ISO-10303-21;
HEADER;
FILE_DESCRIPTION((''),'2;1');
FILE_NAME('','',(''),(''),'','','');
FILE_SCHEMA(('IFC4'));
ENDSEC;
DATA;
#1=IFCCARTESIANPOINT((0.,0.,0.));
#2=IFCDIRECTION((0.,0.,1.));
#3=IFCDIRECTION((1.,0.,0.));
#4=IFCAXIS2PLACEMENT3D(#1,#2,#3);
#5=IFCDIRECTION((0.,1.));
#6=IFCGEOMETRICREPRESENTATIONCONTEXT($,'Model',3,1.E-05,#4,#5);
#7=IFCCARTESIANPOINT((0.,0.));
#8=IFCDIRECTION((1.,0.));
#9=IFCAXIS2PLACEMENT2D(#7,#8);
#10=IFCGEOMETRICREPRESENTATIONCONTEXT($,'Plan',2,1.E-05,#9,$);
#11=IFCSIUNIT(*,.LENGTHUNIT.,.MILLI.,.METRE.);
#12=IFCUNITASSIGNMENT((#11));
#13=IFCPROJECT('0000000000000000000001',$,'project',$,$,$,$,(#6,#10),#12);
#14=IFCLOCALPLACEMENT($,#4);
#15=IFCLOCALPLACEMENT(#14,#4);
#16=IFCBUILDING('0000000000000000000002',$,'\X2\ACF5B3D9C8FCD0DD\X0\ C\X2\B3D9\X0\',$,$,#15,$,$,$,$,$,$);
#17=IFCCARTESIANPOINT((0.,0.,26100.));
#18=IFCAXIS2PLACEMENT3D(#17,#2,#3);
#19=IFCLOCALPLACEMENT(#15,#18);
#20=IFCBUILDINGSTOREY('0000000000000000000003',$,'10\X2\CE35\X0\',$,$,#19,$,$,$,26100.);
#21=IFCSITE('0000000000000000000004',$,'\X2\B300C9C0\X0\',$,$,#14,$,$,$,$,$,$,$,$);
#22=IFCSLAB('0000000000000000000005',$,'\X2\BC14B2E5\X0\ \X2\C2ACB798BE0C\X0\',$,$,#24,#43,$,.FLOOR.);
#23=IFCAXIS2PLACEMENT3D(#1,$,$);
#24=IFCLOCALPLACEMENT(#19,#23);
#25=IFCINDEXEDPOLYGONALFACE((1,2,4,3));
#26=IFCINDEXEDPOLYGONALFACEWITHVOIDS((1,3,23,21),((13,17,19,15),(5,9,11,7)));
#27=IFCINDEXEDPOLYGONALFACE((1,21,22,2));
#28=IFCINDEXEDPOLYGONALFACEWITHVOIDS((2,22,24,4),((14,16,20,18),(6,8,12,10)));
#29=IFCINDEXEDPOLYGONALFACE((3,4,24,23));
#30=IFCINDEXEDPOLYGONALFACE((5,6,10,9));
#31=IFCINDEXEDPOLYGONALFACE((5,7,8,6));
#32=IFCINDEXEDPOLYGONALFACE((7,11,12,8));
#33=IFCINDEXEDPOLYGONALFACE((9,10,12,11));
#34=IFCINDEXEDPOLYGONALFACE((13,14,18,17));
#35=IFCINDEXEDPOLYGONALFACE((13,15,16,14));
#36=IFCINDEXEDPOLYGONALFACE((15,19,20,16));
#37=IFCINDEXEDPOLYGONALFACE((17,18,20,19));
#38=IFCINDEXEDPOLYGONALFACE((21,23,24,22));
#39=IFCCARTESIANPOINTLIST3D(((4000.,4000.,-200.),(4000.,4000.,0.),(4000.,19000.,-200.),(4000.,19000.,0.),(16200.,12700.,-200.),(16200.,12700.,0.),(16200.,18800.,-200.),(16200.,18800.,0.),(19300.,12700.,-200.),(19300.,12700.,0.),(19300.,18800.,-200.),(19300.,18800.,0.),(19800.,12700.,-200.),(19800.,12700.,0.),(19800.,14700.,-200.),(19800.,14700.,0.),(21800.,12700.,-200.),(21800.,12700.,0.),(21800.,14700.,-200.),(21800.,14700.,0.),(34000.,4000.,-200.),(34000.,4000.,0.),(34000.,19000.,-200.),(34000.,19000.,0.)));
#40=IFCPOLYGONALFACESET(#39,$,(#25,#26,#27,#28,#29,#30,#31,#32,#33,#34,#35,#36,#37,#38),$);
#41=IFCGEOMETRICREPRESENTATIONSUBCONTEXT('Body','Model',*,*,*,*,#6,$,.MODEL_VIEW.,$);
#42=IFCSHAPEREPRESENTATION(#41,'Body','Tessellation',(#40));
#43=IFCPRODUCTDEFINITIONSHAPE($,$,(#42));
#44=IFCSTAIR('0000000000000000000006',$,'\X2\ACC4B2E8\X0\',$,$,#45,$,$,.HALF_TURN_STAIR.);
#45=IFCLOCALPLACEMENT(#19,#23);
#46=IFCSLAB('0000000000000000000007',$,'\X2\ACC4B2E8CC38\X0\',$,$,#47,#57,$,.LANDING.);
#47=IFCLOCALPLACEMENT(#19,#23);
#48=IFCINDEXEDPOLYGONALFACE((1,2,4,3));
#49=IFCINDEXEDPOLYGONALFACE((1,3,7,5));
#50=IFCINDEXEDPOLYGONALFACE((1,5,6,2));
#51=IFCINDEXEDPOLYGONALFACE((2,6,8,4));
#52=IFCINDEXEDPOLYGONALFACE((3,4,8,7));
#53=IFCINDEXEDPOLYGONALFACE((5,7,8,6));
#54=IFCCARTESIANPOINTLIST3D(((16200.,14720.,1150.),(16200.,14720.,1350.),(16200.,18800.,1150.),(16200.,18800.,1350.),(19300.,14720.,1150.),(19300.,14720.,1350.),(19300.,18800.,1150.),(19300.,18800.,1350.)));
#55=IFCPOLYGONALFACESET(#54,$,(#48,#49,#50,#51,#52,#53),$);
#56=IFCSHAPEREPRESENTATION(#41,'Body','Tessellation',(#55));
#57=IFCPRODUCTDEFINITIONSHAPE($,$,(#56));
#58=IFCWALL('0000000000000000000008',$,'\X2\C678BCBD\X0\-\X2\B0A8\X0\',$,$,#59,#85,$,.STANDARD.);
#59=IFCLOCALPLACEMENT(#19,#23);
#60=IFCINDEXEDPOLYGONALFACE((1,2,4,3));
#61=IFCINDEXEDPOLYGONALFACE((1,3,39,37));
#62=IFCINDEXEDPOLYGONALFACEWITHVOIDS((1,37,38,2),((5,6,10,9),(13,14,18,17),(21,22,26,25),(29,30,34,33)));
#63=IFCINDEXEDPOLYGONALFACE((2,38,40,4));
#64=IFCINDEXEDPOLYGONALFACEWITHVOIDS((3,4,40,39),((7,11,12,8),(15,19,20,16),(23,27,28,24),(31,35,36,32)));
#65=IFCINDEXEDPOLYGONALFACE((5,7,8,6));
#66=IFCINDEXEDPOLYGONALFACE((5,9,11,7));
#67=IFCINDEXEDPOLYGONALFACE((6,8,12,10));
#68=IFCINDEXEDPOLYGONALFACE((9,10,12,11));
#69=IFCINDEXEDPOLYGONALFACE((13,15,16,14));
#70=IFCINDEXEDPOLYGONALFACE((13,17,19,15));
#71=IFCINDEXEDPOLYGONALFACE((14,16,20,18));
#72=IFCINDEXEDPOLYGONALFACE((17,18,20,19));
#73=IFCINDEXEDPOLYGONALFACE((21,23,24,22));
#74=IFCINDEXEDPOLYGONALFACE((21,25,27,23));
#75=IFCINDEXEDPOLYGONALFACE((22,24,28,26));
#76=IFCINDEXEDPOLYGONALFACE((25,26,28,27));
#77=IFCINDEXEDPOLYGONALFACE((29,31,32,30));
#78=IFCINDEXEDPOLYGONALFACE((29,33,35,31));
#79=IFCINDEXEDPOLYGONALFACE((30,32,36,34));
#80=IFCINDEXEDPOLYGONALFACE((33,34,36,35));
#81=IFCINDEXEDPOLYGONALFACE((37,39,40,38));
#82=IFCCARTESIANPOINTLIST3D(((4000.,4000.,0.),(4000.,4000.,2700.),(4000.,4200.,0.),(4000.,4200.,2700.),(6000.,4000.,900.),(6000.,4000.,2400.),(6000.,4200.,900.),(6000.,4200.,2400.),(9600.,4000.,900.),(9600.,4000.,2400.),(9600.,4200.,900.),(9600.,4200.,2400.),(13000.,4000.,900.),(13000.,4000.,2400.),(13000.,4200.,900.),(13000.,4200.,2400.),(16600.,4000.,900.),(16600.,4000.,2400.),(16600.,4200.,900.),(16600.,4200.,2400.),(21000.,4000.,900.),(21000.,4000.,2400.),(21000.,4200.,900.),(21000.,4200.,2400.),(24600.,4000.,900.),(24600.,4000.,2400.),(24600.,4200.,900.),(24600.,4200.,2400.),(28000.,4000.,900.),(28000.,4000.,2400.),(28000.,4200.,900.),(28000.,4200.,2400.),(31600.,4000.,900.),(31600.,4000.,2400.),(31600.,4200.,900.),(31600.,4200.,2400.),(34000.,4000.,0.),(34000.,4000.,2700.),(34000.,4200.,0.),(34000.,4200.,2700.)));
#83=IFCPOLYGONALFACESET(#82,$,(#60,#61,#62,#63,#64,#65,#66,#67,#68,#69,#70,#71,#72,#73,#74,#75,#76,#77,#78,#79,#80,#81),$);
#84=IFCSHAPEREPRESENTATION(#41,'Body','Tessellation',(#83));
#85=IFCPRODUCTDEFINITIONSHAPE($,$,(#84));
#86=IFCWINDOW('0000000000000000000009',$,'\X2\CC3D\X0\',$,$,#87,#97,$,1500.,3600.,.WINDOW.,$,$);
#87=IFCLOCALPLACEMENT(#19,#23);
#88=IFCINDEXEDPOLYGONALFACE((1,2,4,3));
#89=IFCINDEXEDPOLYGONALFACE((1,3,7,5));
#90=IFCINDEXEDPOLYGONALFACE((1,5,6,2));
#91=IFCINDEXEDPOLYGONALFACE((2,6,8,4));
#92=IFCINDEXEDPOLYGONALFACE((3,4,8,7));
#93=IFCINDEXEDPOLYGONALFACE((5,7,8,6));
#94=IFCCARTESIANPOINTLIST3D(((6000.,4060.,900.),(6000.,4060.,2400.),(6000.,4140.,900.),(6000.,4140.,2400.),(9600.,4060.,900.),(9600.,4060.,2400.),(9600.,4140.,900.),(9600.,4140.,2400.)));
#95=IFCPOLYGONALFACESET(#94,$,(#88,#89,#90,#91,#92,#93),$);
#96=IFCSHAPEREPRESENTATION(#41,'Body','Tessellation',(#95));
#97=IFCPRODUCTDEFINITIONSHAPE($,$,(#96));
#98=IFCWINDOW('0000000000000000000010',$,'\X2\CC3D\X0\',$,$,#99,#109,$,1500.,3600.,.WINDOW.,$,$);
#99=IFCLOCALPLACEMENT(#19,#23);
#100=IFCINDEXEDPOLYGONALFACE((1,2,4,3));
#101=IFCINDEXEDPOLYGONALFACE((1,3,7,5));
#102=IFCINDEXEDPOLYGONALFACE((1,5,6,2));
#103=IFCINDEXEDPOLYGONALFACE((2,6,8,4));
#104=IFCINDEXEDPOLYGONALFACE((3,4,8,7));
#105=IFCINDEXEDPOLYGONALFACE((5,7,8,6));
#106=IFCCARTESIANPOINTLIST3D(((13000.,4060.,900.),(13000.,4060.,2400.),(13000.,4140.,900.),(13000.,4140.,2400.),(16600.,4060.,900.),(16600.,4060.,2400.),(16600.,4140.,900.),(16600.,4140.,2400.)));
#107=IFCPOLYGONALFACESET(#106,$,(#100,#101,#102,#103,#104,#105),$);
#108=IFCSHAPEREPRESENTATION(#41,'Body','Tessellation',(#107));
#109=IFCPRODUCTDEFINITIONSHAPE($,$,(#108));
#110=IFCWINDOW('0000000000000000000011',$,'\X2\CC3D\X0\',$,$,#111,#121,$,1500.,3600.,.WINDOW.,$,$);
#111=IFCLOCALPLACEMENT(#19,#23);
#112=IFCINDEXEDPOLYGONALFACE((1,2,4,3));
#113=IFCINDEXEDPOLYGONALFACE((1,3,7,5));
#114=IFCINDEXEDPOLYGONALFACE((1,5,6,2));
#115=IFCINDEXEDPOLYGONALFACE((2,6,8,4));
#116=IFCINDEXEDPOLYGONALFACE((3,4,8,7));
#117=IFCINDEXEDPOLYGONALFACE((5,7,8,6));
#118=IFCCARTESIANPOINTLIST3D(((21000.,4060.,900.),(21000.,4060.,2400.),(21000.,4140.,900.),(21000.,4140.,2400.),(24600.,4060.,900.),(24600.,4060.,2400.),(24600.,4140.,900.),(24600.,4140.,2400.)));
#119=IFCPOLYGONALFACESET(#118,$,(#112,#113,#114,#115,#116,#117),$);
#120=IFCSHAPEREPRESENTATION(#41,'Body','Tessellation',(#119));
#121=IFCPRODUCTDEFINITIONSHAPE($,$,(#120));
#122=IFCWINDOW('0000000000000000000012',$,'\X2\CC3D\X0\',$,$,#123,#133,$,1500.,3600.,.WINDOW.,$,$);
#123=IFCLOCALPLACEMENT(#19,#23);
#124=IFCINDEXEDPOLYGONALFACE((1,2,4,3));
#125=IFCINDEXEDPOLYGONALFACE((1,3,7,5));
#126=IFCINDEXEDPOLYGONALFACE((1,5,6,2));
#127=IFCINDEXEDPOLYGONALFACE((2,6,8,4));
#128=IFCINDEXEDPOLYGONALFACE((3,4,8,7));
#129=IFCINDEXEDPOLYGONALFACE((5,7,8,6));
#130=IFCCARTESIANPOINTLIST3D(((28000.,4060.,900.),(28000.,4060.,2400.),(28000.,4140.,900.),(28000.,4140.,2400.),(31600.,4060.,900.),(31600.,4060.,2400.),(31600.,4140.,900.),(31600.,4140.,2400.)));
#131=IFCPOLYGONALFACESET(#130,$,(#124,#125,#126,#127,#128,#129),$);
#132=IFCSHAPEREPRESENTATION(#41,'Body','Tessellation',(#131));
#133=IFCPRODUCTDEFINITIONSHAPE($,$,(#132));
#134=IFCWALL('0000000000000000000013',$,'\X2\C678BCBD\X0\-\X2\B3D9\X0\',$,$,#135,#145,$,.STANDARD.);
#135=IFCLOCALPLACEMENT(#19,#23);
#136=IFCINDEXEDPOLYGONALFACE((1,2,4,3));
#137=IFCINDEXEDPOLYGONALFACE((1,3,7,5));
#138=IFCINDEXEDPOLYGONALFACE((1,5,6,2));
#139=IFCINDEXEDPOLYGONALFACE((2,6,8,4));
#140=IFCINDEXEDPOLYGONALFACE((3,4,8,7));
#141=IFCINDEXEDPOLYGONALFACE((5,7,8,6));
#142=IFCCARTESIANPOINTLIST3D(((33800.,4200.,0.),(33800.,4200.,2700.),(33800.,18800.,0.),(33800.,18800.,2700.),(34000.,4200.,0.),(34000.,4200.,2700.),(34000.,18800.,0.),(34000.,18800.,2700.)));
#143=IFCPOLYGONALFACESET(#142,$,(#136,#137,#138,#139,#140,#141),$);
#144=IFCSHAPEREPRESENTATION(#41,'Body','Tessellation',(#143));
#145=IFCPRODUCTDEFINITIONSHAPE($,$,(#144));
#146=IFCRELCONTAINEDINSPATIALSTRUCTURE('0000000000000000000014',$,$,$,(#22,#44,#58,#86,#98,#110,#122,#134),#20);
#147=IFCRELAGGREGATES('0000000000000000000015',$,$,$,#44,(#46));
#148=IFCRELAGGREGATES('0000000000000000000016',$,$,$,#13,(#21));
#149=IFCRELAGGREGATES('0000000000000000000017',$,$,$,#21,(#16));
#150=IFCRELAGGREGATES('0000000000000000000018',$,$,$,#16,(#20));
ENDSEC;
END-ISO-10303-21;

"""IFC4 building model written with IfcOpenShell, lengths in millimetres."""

from ifc_helpers import new_model, si_unit, direction, frame, origin_with_axes, origin_2d_with_axis, place, context, subcontext, project, spatial, polyline, outline, extrude, element, fill, aggregate, save


model = new_model("IFC4")

# Units and contexts
model_context = context("Model", 3, precision=1e-05, world=origin_with_axes(), true_north=direction((0.0, 1.0)))
plan_context = context("Plan", 2, precision=1e-05, world=origin_2d_with_axis())
body_context = subcontext(model_context, "Body", "Model", "MODEL_VIEW")
ifc_project = project(units=[si_unit("LENGTHUNIT", "METRE", prefix="MILLI")], contexts=[model_context, plan_context])

# Site, building, storey
site_placement = place(None, origin_with_axes())
site = spatial("IfcSite", under=ifc_project, at=site_placement, Name="대지")
building_placement = place(site_placement, origin_with_axes())
building = spatial("IfcBuilding", under=site, at=building_placement, Name="공동주택 C동")
storey_placement = place(building_placement, frame((0.0, 0.0, 26100.0), z_axis=(0.0, 0.0, 1.0), x_axis=(1.0, 0.0, 0.0)))
storey = spatial("IfcBuildingStorey", under=building, at=storey_placement, Name="10층", Elevation=26100.0)

# Slab
slab_1_placement = place(storey_placement, origin_with_axes())
element("IfcSlab", 1, at=slab_1_placement, inside=storey, Name="바닥 슬래브", PredefinedType="FLOOR", context=body_context, shape_type="SweptSolid", body=[
    extrude(outline(polyline([(4000.0, 4000.0), (34000.0, 4000.0), (34000.0, 19000.0), (4000.0, 19000.0), (4000.0, 4000.0)]), holes=[polyline([(16200.0, 12700.0), (19300.0, 12700.0), (19300.0, 18800.0), (16200.0, 18800.0), (16200.0, 12700.0)]), polyline([(19800.0, 12700.0), (21800.0, 12700.0), (21800.0, 14700.0), (19800.0, 14700.0), (19800.0, 12700.0)])]), frame((0.0, 0.0, -200.0), z_axis=(0.0, 0.0, 1.0), x_axis=(1.0, 0.0, 0.0)), (0.0, 0.0, 1.0), 200.0),
])

# Stair, slab
stair_placement = place(storey_placement, origin_with_axes())
stair = element("IfcStair", 2, at=stair_placement, inside=storey, Name="계단", PredefinedType="HALF_TURN_STAIR")
slab_2_placement = place(stair_placement, origin_with_axes())
slab_2 = element("IfcSlab", 3, at=slab_2_placement, Name="계단참", PredefinedType="LANDING", context=body_context, shape_type="SweptSolid", body=[
    extrude(outline(polyline([(16200.0, 14720.0), (19300.0, 14720.0), (19300.0, 18800.0), (16200.0, 18800.0), (16200.0, 14720.0)])), frame((0.0, 0.0, 1150.0), z_axis=(0.0, 0.0, 1.0), x_axis=(1.0, 0.0, 0.0)), (0.0, 0.0, 1.0), 200.0),
])

# Wall, openings, windows
wall_1_placement = place(storey_placement, origin_with_axes())
wall_1 = element("IfcWall", 4, at=wall_1_placement, inside=storey, Name="외벽-남", PredefinedType="STANDARD", context=body_context, shape_type="SweptSolid", body=[
    extrude(outline(polyline([(4000.0, 4200.0), (34000.0, 4200.0), (34000.0, 4000.0), (4000.0, 4000.0), (4000.0, 4200.0)])), origin_with_axes(), (0.0, 0.0, 1.0), 2700.0),
])
opening_1_placement = place(storey_placement, origin_with_axes())
opening_1 = element("IfcOpeningElement", 5, at=opening_1_placement, cuts=wall_1, PredefinedType="OPENING", context=body_context, shape_type="SweptSolid", body=[
    extrude(outline(polyline([(6000.0, 3950.0), (9600.0, 3950.0), (9600.0, 4250.0), (6000.0, 4250.0), (6000.0, 3950.0)])), frame((0.0, 0.0, 900.0), z_axis=(0.0, 0.0, 1.0), x_axis=(1.0, 0.0, 0.0)), (0.0, 0.0, 1.0), 1500.0),
])
opening_2_placement = place(storey_placement, origin_with_axes())
opening_2 = element("IfcOpeningElement", 6, at=opening_2_placement, cuts=wall_1, PredefinedType="OPENING", context=body_context, shape_type="SweptSolid", body=[
    extrude(outline(polyline([(13000.0, 3950.0), (16600.0, 3950.0), (16600.0, 4250.0), (13000.0, 4250.0), (13000.0, 3950.0)])), frame((0.0, 0.0, 900.0), z_axis=(0.0, 0.0, 1.0), x_axis=(1.0, 0.0, 0.0)), (0.0, 0.0, 1.0), 1500.0),
])
opening_3_placement = place(storey_placement, origin_with_axes())
opening_3 = element("IfcOpeningElement", 7, at=opening_3_placement, cuts=wall_1, PredefinedType="OPENING", context=body_context, shape_type="SweptSolid", body=[
    extrude(outline(polyline([(21000.0, 3950.0), (24600.0, 3950.0), (24600.0, 4250.0), (21000.0, 4250.0), (21000.0, 3950.0)])), frame((0.0, 0.0, 900.0), z_axis=(0.0, 0.0, 1.0), x_axis=(1.0, 0.0, 0.0)), (0.0, 0.0, 1.0), 1500.0),
])
opening_4_placement = place(storey_placement, origin_with_axes())
opening_4 = element("IfcOpeningElement", 8, at=opening_4_placement, cuts=wall_1, PredefinedType="OPENING", context=body_context, shape_type="SweptSolid", body=[
    extrude(outline(polyline([(28000.0, 3950.0), (31600.0, 3950.0), (31600.0, 4250.0), (28000.0, 4250.0), (28000.0, 3950.0)])), frame((0.0, 0.0, 900.0), z_axis=(0.0, 0.0, 1.0), x_axis=(1.0, 0.0, 0.0)), (0.0, 0.0, 1.0), 1500.0),
])
window_1_placement = place(storey_placement, origin_with_axes())
window_1 = element("IfcWindow", 9, at=window_1_placement, inside=storey, Name="창", OverallHeight=1500.0, OverallWidth=3600.0, PredefinedType="WINDOW", context=body_context, shape_type="SweptSolid", body=[
    extrude(outline(polyline([(6000.0, 4060.0), (9600.0, 4060.0), (9600.0, 4140.0), (6000.0, 4140.0), (6000.0, 4060.0)])), frame((0.0, 0.0, 900.0), z_axis=(0.0, 0.0, 1.0), x_axis=(1.0, 0.0, 0.0)), (0.0, 0.0, 1.0), 1500.0),
])
fill(opening_1, window_1)
window_2_placement = place(storey_placement, origin_with_axes())
window_2 = element("IfcWindow", 10, at=window_2_placement, inside=storey, Name="창", OverallHeight=1500.0, OverallWidth=3600.0, PredefinedType="WINDOW", context=body_context, shape_type="SweptSolid", body=[
    extrude(outline(polyline([(13000.0, 4060.0), (16600.0, 4060.0), (16600.0, 4140.0), (13000.0, 4140.0), (13000.0, 4060.0)])), frame((0.0, 0.0, 900.0), z_axis=(0.0, 0.0, 1.0), x_axis=(1.0, 0.0, 0.0)), (0.0, 0.0, 1.0), 1500.0),
])
fill(opening_2, window_2)
window_3_placement = place(storey_placement, origin_with_axes())
window_3 = element("IfcWindow", 11, at=window_3_placement, inside=storey, Name="창", OverallHeight=1500.0, OverallWidth=3600.0, PredefinedType="WINDOW", context=body_context, shape_type="SweptSolid", body=[
    extrude(outline(polyline([(21000.0, 4060.0), (24600.0, 4060.0), (24600.0, 4140.0), (21000.0, 4140.0), (21000.0, 4060.0)])), frame((0.0, 0.0, 900.0), z_axis=(0.0, 0.0, 1.0), x_axis=(1.0, 0.0, 0.0)), (0.0, 0.0, 1.0), 1500.0),
])
fill(opening_3, window_3)
window_4_placement = place(storey_placement, origin_with_axes())
window_4 = element("IfcWindow", 12, at=window_4_placement, inside=storey, Name="창", OverallHeight=1500.0, OverallWidth=3600.0, PredefinedType="WINDOW", context=body_context, shape_type="SweptSolid", body=[
    extrude(outline(polyline([(28000.0, 4060.0), (31600.0, 4060.0), (31600.0, 4140.0), (28000.0, 4140.0), (28000.0, 4060.0)])), frame((0.0, 0.0, 900.0), z_axis=(0.0, 0.0, 1.0), x_axis=(1.0, 0.0, 0.0)), (0.0, 0.0, 1.0), 1500.0),
])
fill(opening_4, window_4)

# Wall
wall_2_placement = place(storey_placement, origin_with_axes())
element("IfcWall", 13, at=wall_2_placement, inside=storey, Name="외벽-동", PredefinedType="STANDARD", context=body_context, shape_type="SweptSolid", body=[
    extrude(outline(polyline([(33800.0, 4200.0), (33800.0, 18800.0), (34000.0, 18800.0), (34000.0, 4200.0), (33800.0, 4200.0)])), origin_with_axes(), (0.0, 0.0, 1.0), 2700.0),
])

aggregate(stair, [slab_2])

save(model, "model.ifc")
